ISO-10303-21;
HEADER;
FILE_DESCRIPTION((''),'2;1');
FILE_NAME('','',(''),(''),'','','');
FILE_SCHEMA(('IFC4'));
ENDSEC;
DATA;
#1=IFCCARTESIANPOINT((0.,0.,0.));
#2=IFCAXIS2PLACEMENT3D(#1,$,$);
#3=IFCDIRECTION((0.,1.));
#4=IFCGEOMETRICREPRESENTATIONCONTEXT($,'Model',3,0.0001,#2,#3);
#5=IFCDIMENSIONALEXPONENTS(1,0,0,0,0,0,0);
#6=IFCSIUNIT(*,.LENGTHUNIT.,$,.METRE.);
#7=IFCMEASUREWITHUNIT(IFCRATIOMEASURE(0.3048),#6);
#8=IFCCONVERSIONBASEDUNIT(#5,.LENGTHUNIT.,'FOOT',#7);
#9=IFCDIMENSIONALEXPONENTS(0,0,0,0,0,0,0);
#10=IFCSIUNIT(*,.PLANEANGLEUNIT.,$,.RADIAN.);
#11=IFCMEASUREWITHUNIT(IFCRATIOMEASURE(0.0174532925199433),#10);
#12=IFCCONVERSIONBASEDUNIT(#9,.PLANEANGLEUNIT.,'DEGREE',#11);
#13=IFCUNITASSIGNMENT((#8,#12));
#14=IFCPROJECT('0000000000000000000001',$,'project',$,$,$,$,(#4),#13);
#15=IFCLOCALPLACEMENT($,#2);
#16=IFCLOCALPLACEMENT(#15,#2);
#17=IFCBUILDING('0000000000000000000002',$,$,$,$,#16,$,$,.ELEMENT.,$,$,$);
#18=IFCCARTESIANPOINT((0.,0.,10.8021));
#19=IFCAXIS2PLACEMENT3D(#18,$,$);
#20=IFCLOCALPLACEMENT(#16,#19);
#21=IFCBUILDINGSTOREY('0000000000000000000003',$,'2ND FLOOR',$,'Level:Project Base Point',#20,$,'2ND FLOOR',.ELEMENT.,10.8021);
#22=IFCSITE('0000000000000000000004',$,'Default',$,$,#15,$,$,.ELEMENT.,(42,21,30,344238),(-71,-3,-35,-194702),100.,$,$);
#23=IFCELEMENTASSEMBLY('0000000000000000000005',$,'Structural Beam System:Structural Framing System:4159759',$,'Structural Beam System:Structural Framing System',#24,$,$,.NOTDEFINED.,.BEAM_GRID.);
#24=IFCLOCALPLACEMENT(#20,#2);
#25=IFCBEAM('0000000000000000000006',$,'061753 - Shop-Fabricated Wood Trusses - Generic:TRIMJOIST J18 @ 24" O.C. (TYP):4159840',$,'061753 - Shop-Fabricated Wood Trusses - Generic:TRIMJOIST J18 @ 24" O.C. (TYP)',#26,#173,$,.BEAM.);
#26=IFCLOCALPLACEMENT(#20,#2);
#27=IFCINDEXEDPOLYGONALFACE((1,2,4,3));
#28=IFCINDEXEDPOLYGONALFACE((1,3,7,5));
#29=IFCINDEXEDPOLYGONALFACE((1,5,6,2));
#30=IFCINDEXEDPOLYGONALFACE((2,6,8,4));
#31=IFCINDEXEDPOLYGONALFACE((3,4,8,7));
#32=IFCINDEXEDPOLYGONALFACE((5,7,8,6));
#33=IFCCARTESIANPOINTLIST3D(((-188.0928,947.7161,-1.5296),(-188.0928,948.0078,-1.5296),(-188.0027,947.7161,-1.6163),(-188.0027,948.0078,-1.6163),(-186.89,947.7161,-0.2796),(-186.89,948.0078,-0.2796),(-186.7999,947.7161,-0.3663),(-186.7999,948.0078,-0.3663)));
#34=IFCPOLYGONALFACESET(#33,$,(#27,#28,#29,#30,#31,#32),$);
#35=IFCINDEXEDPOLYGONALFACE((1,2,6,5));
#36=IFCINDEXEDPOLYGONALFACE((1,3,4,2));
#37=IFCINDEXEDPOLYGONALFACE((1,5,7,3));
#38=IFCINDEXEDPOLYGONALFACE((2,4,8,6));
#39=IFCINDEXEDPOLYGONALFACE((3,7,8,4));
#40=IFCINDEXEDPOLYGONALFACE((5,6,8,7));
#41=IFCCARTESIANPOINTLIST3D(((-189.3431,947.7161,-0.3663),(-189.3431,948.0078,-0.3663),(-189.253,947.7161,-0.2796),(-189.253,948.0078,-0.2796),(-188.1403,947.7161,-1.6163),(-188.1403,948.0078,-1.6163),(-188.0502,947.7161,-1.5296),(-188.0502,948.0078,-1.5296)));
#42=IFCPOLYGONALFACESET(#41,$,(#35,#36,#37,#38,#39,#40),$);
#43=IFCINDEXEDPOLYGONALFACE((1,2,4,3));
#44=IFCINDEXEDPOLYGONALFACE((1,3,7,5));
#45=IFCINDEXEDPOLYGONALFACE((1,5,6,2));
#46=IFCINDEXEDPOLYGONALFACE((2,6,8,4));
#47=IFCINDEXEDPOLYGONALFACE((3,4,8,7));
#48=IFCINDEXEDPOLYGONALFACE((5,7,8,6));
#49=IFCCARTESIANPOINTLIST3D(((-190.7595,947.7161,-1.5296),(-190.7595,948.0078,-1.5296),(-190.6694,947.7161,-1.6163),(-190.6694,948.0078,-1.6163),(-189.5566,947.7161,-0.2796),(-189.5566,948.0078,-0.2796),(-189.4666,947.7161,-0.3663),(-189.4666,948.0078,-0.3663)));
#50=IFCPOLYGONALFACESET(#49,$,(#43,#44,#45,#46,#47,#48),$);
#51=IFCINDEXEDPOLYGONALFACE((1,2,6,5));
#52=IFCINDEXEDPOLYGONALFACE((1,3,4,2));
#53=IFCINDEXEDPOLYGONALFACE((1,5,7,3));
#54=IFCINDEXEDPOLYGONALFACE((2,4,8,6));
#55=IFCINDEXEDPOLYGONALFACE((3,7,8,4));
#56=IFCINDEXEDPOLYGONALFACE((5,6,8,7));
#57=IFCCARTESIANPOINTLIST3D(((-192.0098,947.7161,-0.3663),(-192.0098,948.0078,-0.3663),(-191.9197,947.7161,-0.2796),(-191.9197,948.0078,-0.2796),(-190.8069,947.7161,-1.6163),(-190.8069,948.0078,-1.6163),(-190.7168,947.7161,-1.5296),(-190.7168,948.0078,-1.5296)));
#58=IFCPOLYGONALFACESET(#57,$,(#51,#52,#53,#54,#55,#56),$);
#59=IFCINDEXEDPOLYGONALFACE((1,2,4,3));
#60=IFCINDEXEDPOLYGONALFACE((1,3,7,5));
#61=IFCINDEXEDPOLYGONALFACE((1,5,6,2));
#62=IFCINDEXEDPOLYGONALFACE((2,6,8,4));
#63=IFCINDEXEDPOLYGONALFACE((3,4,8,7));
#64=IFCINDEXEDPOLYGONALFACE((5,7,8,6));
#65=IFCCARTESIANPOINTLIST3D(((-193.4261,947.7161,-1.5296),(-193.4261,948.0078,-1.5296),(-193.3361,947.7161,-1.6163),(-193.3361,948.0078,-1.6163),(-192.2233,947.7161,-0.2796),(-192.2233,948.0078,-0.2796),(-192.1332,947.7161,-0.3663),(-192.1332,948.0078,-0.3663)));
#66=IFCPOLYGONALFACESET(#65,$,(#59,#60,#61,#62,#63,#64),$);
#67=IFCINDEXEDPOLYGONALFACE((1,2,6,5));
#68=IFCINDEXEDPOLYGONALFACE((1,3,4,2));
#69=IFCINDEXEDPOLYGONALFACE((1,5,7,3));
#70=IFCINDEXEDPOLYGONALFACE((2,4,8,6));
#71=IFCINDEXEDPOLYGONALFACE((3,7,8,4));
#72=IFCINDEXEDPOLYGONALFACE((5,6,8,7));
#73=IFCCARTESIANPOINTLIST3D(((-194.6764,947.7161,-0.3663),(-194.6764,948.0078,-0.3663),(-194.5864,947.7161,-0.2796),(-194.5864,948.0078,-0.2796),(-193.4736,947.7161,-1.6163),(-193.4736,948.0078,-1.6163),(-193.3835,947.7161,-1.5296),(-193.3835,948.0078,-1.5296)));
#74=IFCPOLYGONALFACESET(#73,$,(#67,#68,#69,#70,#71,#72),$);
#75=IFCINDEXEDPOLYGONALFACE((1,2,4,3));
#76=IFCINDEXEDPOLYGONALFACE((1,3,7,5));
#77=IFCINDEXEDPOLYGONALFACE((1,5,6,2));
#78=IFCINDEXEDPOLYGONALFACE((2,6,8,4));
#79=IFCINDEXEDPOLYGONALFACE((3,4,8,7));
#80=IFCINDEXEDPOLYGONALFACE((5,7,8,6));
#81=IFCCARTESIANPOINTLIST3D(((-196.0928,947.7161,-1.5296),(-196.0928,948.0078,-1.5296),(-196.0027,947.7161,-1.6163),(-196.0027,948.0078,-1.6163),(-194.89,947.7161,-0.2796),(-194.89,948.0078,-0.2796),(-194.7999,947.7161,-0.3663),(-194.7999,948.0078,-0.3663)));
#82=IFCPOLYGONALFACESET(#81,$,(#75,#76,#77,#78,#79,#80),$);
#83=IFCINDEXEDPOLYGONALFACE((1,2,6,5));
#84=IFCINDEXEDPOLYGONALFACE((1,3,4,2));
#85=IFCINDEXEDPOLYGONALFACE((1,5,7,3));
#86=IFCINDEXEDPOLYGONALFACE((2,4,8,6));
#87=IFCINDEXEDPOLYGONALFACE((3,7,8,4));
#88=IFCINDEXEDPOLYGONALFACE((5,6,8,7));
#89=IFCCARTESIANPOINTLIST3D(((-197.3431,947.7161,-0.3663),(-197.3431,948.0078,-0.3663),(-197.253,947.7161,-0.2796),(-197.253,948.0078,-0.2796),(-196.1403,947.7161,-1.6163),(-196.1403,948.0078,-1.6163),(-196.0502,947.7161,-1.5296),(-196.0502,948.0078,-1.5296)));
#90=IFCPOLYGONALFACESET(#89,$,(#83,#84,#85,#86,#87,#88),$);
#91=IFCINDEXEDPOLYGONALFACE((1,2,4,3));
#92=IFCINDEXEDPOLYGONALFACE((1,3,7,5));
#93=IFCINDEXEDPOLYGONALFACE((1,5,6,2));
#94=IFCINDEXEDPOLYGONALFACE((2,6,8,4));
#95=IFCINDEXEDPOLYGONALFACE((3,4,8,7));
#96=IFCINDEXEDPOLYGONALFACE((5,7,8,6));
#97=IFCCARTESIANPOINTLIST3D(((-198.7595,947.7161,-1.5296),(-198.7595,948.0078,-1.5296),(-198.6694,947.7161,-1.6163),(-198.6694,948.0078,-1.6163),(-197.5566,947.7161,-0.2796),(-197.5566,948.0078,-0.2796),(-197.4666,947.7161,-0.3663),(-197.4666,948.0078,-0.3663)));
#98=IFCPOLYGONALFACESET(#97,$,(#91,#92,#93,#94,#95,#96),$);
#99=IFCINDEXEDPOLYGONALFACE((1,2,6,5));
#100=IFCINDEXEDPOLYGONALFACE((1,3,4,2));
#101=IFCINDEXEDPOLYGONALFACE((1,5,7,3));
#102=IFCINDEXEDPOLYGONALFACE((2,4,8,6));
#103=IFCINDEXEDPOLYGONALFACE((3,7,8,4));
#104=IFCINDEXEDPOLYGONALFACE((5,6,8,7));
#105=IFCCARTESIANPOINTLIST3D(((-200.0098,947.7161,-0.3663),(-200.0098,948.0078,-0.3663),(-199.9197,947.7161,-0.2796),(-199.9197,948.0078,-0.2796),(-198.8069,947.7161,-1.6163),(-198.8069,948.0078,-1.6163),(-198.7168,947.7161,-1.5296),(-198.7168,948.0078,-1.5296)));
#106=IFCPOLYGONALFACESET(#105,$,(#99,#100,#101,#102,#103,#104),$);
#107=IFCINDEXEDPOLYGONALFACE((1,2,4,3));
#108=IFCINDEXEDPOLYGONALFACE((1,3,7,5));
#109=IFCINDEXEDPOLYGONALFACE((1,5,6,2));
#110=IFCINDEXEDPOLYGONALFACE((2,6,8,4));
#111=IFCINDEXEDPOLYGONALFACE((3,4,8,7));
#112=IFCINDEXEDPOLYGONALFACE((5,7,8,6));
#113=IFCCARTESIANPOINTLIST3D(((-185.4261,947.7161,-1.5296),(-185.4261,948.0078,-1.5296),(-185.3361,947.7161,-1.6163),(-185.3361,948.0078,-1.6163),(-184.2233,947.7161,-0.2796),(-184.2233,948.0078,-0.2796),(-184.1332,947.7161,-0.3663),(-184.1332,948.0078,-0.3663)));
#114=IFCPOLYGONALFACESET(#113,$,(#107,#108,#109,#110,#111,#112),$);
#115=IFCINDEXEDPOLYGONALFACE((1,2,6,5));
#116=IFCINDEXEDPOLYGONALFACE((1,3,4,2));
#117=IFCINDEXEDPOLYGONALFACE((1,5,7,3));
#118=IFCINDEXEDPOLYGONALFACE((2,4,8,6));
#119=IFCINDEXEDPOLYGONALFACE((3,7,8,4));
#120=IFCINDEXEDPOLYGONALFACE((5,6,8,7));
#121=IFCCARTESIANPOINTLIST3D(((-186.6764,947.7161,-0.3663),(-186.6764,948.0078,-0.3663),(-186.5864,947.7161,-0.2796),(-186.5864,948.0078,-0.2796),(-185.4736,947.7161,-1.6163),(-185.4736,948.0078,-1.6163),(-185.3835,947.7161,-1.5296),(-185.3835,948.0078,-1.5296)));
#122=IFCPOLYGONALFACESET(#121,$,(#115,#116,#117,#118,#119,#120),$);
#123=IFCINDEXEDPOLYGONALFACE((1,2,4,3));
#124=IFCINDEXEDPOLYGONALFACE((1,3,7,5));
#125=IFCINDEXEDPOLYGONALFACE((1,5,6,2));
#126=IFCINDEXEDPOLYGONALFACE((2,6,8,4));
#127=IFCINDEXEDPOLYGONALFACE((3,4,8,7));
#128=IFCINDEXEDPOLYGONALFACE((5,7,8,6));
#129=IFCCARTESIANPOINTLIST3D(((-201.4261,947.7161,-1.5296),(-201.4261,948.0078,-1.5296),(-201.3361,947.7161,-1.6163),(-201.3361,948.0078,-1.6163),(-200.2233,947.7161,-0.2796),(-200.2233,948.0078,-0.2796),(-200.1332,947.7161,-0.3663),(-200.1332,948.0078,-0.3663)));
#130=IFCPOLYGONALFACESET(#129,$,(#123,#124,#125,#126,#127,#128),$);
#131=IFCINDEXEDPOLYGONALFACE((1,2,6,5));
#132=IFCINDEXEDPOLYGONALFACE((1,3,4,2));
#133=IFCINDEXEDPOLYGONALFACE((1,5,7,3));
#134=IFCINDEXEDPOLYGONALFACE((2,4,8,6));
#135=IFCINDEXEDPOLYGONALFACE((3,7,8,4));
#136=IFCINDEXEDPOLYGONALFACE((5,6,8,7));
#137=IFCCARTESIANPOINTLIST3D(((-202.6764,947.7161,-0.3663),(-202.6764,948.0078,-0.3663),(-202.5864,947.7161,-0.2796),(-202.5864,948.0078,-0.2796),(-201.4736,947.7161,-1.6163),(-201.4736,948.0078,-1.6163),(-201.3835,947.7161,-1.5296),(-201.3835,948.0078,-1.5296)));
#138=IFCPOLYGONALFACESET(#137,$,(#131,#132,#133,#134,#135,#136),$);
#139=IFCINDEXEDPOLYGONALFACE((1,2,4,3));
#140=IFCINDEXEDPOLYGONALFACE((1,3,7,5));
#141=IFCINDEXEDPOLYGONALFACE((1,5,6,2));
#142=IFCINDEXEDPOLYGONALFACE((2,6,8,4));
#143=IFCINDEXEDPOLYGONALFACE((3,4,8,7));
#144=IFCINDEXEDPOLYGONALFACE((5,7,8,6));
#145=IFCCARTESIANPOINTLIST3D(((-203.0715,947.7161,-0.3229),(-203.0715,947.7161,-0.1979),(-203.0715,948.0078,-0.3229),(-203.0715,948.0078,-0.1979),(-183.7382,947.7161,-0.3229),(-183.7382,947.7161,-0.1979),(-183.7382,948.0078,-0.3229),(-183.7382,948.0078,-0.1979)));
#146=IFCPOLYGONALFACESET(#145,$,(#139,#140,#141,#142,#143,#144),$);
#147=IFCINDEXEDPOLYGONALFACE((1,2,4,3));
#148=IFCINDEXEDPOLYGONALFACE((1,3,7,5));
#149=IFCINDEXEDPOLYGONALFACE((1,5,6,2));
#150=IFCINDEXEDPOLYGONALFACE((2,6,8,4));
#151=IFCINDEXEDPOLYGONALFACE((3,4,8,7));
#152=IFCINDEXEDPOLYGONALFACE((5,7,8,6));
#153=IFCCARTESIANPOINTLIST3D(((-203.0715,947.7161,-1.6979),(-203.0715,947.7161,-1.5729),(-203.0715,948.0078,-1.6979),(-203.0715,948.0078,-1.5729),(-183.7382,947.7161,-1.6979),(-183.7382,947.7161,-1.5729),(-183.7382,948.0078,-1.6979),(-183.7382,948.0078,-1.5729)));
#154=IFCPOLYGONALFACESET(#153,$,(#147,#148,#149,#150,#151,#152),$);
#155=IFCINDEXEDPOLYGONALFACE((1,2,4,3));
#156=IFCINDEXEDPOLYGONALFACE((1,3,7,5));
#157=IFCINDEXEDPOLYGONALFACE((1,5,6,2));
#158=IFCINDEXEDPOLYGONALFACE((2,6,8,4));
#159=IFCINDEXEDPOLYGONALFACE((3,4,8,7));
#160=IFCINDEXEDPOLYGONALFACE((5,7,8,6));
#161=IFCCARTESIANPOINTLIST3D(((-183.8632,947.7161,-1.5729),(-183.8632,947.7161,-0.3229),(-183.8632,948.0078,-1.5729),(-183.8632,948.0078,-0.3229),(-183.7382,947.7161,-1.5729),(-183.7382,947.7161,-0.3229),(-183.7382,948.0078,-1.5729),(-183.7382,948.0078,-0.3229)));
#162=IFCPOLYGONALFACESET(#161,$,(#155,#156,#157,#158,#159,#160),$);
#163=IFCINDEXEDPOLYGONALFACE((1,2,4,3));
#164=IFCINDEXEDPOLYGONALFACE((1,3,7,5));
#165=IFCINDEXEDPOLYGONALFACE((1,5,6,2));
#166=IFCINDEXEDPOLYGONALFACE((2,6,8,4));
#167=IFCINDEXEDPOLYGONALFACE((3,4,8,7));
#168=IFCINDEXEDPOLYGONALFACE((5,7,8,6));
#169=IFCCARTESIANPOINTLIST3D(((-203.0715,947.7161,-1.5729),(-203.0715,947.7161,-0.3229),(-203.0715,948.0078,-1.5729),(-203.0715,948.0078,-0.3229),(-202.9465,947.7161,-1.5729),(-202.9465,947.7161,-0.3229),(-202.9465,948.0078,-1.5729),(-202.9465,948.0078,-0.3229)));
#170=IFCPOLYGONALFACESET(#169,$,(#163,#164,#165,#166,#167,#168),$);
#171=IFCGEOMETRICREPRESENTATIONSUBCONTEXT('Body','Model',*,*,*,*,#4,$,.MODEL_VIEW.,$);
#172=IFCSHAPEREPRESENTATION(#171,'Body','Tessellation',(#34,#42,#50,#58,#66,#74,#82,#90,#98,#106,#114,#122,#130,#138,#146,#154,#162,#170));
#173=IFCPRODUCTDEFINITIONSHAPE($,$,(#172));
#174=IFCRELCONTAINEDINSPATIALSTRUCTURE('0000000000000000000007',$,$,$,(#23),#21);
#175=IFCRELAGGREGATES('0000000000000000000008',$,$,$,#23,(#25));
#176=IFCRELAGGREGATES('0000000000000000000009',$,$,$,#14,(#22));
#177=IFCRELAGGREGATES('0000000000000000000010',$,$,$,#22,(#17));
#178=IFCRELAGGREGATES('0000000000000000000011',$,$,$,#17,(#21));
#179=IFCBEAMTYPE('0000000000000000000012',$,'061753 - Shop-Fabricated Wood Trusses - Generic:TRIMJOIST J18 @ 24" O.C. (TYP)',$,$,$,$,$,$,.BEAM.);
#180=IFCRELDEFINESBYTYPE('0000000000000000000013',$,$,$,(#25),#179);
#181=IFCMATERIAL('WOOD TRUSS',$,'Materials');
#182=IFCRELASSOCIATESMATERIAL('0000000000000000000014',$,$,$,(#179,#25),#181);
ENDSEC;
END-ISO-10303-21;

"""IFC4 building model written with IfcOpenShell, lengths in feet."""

from ifc_helpers import new_model, entity, si_unit, converted_unit, direction, frame, frame_2d, origin, origin_2d_with_axis, place, context, subcontext, project, spatial, rectangle, extrude, source, transform, mapped, material, material_profile, profile_set, profile_usage, type_object, type_shapes, element, aggregate, save


model = new_model("IFC4")

# Units and contexts
model_context = context("Model", 3, precision=0.0001, world=origin(), true_north=direction((0.0, 1.0)))
body_context = subcontext(model_context, "Body", "Model", "MODEL_VIEW")
ifc_project = project(units=[converted_unit("LENGTHUNIT", "FOOT", entity("IfcRatioMeasure", 0.3048), si_unit("LENGTHUNIT", "METRE"), dimensions=[1, 0, 0, 0, 0, 0, 0]), converted_unit("PLANEANGLEUNIT", "DEGREE", entity("IfcRatioMeasure", 0.0174532925199433), si_unit("PLANEANGLEUNIT", "RADIAN"), dimensions=[0, 0, 0, 0, 0, 0, 0])], contexts=[model_context])

# Site, building, storey
site_placement = place(None, origin())
site = spatial("IfcSite", under=ifc_project, at=site_placement, Name="Default", CompositionType="ELEMENT", RefLatitude=(42, 21, 30, 344238), RefLongitude=(-71, -3, -35, -194702), RefElevation=100.0)
building_placement = place(site_placement, origin())
building = spatial("IfcBuilding", under=site, at=building_placement, CompositionType="ELEMENT")
storey_placement = place(building_placement, frame((0.0, 0.0, 10.8021)))
storey = spatial("IfcBuildingStorey", under=building, at=storey_placement, Name="2ND FLOOR", ObjectType="Level:Project Base Point", LongName="2ND FLOOR", CompositionType="ELEMENT", Elevation=10.8021)

# Element assembly, beam
ifc_material_1 = material(Name="WOOD TRUSS", Category="Materials")
ifc_material_profile_1 = material_profile(ifc_material_1, rectangle(XDim=1.7347, YDim=0.125, at=frame_2d((0.0, 0.0), x_axis=(1.0, 0.0))), Name="TRIMJOIST J18 @ 24\" O.C. (TYP)")
ifc_material_profile_2 = material_profile(ifc_material_1, rectangle(XDim=1.7347, YDim=0.125, at=frame_2d((0.0, 0.0), x_axis=(1.0, 0.0))), Name="TRIMJOIST J18 @ 24\" O.C. (TYP)")
ifc_material_profile_3 = material_profile(ifc_material_1, rectangle(XDim=1.7347, YDim=0.125, at=frame_2d((0.0, 0.0), x_axis=(1.0, 0.0))), Name="TRIMJOIST J18 @ 24\" O.C. (TYP)")
ifc_material_profile_4 = material_profile(ifc_material_1, rectangle(XDim=1.7347, YDim=0.125, at=frame_2d((0.0, 0.0), x_axis=(1.0, 0.0))), Name="TRIMJOIST J18 @ 24\" O.C. (TYP)")
ifc_material_profile_5 = material_profile(ifc_material_1, rectangle(XDim=1.7347, YDim=0.125, at=frame_2d((0.0, 0.0), x_axis=(1.0, 0.0))), Name="TRIMJOIST J18 @ 24\" O.C. (TYP)")
ifc_material_profile_6 = material_profile(ifc_material_1, rectangle(XDim=1.7347, YDim=0.125, at=frame_2d((0.0, 0.0), x_axis=(1.0, 0.0))), Name="TRIMJOIST J18 @ 24\" O.C. (TYP)")
ifc_material_profile_7 = material_profile(ifc_material_1, rectangle(XDim=1.7347, YDim=0.125, at=frame_2d((0.0, 0.0), x_axis=(1.0, 0.0))), Name="TRIMJOIST J18 @ 24\" O.C. (TYP)")
ifc_material_profile_8 = material_profile(ifc_material_1, rectangle(XDim=1.7347, YDim=0.125, at=frame_2d((0.0, 0.0), x_axis=(1.0, 0.0))), Name="TRIMJOIST J18 @ 24\" O.C. (TYP)")
ifc_material_profile_9 = material_profile(ifc_material_1, rectangle(XDim=1.7347, YDim=0.125, at=frame_2d((0.0, 0.0), x_axis=(1.0, 0.0))), Name="TRIMJOIST J18 @ 24\" O.C. (TYP)")
ifc_material_profile_10 = material_profile(ifc_material_1, rectangle(XDim=1.7347, YDim=0.125, at=origin_2d_with_axis()), Name="TRIMJOIST J18 @ 24\" O.C. (TYP)")
ifc_material_profile_11 = material_profile(ifc_material_1, rectangle(XDim=0.125, YDim=0.2917, at=origin_2d_with_axis()), Name="TRIMJOIST J18 @ 24\" O.C. (TYP)")
ifc_material_profile_12 = material_profile(ifc_material_1, rectangle(XDim=0.125, YDim=0.2917, at=origin_2d_with_axis()), Name="TRIMJOIST J18 @ 24\" O.C. (TYP)")
ifc_material_profile_13 = material_profile(ifc_material_1, rectangle(XDim=1.25, YDim=0.2917, at=origin_2d_with_axis()), Name="TRIMJOIST J18 @ 24\" O.C. (TYP)")
ifc_material_profile_14 = material_profile(ifc_material_1, rectangle(XDim=1.25, YDim=0.2917, at=origin_2d_with_axis()), Name="TRIMJOIST J18 @ 24\" O.C. (TYP)")
ifc_profile_set_1 = profile_set([ifc_material_profile_1, ifc_material_profile_2, ifc_material_profile_3, ifc_material_profile_4, ifc_material_profile_5, ifc_material_profile_6, ifc_material_profile_7, ifc_material_profile_8, ifc_material_profile_9, ifc_material_profile_10, ifc_material_profile_11, ifc_material_profile_12, ifc_material_profile_13, ifc_material_profile_14], Name="TRIMJOIST J18 @ 24\" O.C. (TYP)")
beam_type_1 = type_object("IfcBeamType", Name="061753 - Shop-Fabricated Wood Trusses - Generic:TRIMJOIST J18 @ 24\" O.C. (TYP)", PredefinedType="BEAM", material=ifc_profile_set_1)
shared_shape_1 = source(origin(), body_context, "Body", "SweptSolid", [
    extrude(rectangle(XDim=1.7347, YDim=0.125, at=frame_2d((0.0, 0.0), x_axis=(1.0, 0.0))), frame((5.9585, -0.1458, 0.0), z_axis=(0.0, 1.0, 0.0), x_axis=(0.693383, 0.0, 0.720569)), (0.0, 0.0, 1.0), 0.2917),
    extrude(rectangle(XDim=1.7347, YDim=0.125, at=origin_2d_with_axis()), frame((4.7082, -0.1458, 0.0), z_axis=(0.0, 1.0, 0.0), x_axis=(0.693383, 0.0, -0.720569)), (0.0, 0.0, 1.0), 0.2917),
    extrude(rectangle(XDim=1.7347, YDim=0.125, at=frame_2d((0.0, 0.0), x_axis=(1.0, 0.0))), frame((3.2918, -0.1458, 0.0), z_axis=(0.0, 1.0, 0.0), x_axis=(0.693383, 0.0, 0.720569)), (0.0, 0.0, 1.0), 0.2917),
    extrude(rectangle(XDim=1.7347, YDim=0.125, at=frame_2d((0.0, 0.0), x_axis=(1.0, 0.0))), frame((2.0415, -0.1458, 0.0), z_axis=(0.0, 1.0, 0.0), x_axis=(0.693383, 0.0, -0.720569)), (0.0, 0.0, 1.0), 0.2917),
    extrude(rectangle(XDim=1.7347, YDim=0.125, at=frame_2d((0.0, 0.0), x_axis=(1.0, 0.0))), frame((0.6251, -0.1458, 0.0), z_axis=(0.0, 1.0, 0.0), x_axis=(0.693383, 0.0, 0.720569)), (0.0, 0.0, 1.0), 0.2917),
    extrude(rectangle(XDim=1.7347, YDim=0.125, at=frame_2d((0.0, 0.0), x_axis=(1.0, 0.0))), frame((-0.6251, -0.1458, 0.0), z_axis=(0.0, 1.0, 0.0), x_axis=(0.693383, 0.0, -0.720569)), (0.0, 0.0, 1.0), 0.2917),
    extrude(rectangle(XDim=1.7347, YDim=0.125, at=frame_2d((0.0, 0.0), x_axis=(1.0, 0.0))), frame((-2.0415, -0.1458, 0.0), z_axis=(0.0, 1.0, 0.0), x_axis=(0.693383, 0.0, 0.720569)), (0.0, 0.0, 1.0), 0.2917),
    extrude(rectangle(XDim=1.7347, YDim=0.125, at=origin_2d_with_axis()), frame((-3.2918, -0.1458, 0.0), z_axis=(0.0, 1.0, 0.0), x_axis=(0.693383, 0.0, -0.720569)), (0.0, 0.0, 1.0), 0.2917),
    extrude(rectangle(XDim=1.7347, YDim=0.125, at=frame_2d((0.0, 0.0), x_axis=(1.0, 0.0))), frame((-4.7082, -0.1458, 0.0), z_axis=(0.0, 1.0, 0.0), x_axis=(0.693383, 0.0, 0.720569)), (0.0, 0.0, 1.0), 0.2917),
    extrude(rectangle(XDim=1.7347, YDim=0.125, at=frame_2d((0.0, 0.0), x_axis=(1.0, 0.0))), frame((-5.9585, -0.1458, 0.0), z_axis=(0.0, 1.0, 0.0), x_axis=(0.693383, 0.0, -0.720569)), (0.0, 0.0, 1.0), 0.2917),
    extrude(rectangle(XDim=1.7347, YDim=0.125, at=frame_2d((0.0, 0.0), x_axis=(1.0, 0.0))), frame((8.6251, -0.1458, 0.0), z_axis=(0.0, 1.0, 0.0), x_axis=(0.693383, 0.0, 0.720569)), (0.0, 0.0, 1.0), 0.2917),
    extrude(rectangle(XDim=1.7347, YDim=0.125, at=origin_2d_with_axis()), frame((7.3749, -0.1458, 0.0), z_axis=(0.0, 1.0, 0.0), x_axis=(0.693383, 0.0, -0.720569)), (0.0, 0.0, 1.0), 0.2917),
    extrude(rectangle(XDim=1.7347, YDim=0.125, at=frame_2d((0.0, 0.0), x_axis=(1.0, 0.0))), frame((-7.3749, -0.1458, 0.0), z_axis=(0.0, 1.0, 0.0), x_axis=(0.693383, 0.0, 0.720569)), (0.0, 0.0, 1.0), 0.2917),
    extrude(rectangle(XDim=1.7347, YDim=0.125, at=origin_2d_with_axis()), frame((-8.6251, -0.1458, 0.0), z_axis=(0.0, 1.0, 0.0), x_axis=(0.693383, 0.0, -0.720569)), (0.0, 0.0, 1.0), 0.2917),
    extrude(rectangle(XDim=0.125, YDim=0.2917, at=origin_2d_with_axis()), frame((-9.6667, 0.0, 0.6875), z_axis=(1.0, 0.0, 0.0), x_axis=(0.0, 0.0, -1.0)), (0.0, 0.0, 1.0), 19.3333),
    extrude(rectangle(XDim=0.125, YDim=0.2917, at=origin_2d_with_axis()), frame((-9.6667, 0.0, -0.6875), z_axis=(1.0, 0.0, 0.0), x_axis=(0.0, 0.0, -1.0)), (0.0, 0.0, 1.0), 19.3333),
    extrude(rectangle(XDim=1.25, YDim=0.2917, at=origin_2d_with_axis()), frame((9.5417, 0.0, 0.0), z_axis=(1.0, 0.0, 0.0), x_axis=(0.0, 0.0, -1.0)), (0.0, 0.0, 1.0), 0.125),
    extrude(rectangle(XDim=1.25, YDim=0.2917, at=origin_2d_with_axis()), frame((-9.6667, 0.0, 0.0), z_axis=(1.0, 0.0, 0.0), x_axis=(0.0, 0.0, -1.0)), (0.0, 0.0, 1.0), 0.125),
])
type_shapes(beam_type_1, [shared_shape_1])
assembly_1_placement = place(storey_placement, origin())
assembly_1 = element("IfcElementAssembly", 1, at=assembly_1_placement, inside=storey, Name="Structural Beam System:Structural Framing System:4159759", ObjectType="Structural Beam System:Structural Framing System", AssemblyPlace="NOTDEFINED", PredefinedType="BEAM_GRID")
ifc_profile_usage_1 = profile_usage(ifc_profile_set_1, cardinal=8)
beam_1_placement = place(assembly_1_placement, frame((-193.4048, 947.8619, -0.9479)))
beam_1 = element("IfcBeam", 2, at=beam_1_placement, type_object=beam_type_1, material=ifc_profile_usage_1, Name="061753 - Shop-Fabricated Wood Trusses - Generic:TRIMJOIST J18 @ 24\" O.C. (TYP):4159840", ObjectType="061753 - Shop-Fabricated Wood Trusses - Generic:TRIMJOIST J18 @ 24\" O.C. (TYP)", PredefinedType="BEAM", context=body_context, shape_type="MappedRepresentation", body=[
    mapped(shared_shape_1, transform((0.0, 0.0, 0.0), scale=1.0)),
])

aggregate(assembly_1, [beam_1])

save(model, "model.ifc")
